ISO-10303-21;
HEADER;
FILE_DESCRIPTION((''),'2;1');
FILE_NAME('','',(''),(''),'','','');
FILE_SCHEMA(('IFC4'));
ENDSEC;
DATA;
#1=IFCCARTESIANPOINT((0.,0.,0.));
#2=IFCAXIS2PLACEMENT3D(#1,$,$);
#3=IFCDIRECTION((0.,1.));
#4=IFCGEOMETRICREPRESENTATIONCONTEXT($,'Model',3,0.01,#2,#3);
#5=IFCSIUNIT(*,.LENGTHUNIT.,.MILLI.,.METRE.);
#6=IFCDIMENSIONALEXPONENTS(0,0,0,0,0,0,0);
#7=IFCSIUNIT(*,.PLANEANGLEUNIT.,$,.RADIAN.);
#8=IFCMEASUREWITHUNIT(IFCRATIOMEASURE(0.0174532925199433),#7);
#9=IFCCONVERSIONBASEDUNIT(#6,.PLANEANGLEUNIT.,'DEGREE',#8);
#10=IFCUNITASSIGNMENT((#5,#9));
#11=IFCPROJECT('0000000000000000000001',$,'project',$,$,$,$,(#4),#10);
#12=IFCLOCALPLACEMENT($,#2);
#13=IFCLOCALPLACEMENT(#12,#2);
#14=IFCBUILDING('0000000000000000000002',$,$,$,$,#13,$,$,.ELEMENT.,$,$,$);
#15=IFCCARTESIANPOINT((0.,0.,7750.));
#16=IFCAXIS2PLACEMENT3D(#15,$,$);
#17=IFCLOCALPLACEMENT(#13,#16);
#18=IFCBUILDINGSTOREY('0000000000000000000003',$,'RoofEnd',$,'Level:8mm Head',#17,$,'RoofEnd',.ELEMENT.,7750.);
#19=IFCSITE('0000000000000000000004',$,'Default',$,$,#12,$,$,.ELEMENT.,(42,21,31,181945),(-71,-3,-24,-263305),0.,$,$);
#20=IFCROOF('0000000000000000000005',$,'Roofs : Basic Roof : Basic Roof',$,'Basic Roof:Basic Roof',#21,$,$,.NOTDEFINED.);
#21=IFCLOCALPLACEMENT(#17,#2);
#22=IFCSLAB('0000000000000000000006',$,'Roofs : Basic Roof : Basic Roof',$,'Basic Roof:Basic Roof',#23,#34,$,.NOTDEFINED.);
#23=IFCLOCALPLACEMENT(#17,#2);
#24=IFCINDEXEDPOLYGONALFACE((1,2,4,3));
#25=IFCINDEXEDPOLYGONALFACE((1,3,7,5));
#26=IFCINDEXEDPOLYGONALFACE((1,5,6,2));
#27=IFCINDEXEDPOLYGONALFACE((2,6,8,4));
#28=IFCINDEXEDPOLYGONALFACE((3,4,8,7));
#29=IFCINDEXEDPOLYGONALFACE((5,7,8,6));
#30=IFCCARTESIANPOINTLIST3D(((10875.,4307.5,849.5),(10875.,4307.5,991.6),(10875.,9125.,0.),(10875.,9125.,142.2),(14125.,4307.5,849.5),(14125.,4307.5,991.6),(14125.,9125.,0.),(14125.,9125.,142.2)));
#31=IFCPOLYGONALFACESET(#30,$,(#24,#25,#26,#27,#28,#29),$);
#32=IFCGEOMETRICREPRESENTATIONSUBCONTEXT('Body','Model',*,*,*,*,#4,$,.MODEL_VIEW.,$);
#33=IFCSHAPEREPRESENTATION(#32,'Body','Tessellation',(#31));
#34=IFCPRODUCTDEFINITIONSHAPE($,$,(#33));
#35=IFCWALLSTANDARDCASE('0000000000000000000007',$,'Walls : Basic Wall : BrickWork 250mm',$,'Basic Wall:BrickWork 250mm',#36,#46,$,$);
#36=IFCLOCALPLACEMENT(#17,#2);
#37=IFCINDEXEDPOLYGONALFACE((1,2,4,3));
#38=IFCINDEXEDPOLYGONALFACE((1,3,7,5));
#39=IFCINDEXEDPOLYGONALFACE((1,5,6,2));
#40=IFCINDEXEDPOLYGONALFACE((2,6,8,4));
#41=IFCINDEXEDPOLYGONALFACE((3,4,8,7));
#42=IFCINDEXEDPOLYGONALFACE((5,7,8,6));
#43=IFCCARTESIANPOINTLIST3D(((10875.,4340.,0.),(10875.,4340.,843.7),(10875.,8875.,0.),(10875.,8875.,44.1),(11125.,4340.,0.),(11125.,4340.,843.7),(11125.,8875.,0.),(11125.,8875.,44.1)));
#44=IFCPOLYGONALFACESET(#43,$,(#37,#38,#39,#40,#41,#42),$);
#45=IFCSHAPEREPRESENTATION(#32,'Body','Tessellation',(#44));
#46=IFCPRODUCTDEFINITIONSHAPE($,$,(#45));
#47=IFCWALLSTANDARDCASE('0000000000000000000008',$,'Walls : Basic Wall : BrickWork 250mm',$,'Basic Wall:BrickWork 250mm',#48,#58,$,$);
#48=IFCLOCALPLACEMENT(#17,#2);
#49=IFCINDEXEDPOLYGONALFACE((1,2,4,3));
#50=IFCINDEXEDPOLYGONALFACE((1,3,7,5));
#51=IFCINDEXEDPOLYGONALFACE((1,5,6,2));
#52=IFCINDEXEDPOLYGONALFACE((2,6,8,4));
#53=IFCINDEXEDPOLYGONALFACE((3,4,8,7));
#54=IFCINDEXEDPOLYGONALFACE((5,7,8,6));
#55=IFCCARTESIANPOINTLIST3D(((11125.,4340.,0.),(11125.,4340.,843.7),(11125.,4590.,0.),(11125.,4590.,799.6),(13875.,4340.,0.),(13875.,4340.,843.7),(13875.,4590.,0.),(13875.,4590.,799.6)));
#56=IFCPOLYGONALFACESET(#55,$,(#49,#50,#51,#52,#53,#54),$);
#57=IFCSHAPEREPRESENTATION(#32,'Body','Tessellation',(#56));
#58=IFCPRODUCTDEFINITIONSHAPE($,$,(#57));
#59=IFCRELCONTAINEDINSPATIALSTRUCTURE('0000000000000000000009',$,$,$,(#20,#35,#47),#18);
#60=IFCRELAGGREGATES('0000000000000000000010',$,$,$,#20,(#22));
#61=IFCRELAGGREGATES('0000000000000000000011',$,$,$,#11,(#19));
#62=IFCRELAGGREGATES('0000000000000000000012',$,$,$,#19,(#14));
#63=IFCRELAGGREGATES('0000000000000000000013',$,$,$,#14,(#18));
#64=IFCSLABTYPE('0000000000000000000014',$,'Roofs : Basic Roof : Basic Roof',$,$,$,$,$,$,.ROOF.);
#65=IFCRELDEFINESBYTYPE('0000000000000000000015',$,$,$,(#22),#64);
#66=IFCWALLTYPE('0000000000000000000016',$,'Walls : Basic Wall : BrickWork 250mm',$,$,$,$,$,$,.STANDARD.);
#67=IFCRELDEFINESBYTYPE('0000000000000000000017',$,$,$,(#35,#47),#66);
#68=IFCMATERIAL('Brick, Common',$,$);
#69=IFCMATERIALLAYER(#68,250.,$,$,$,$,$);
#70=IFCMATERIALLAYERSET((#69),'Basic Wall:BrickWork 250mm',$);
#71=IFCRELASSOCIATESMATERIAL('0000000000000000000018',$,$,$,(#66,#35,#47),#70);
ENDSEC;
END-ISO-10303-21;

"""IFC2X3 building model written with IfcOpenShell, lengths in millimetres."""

from ifc_helpers import new_model, entity, si_unit, converted_unit, direction, frame, frame_2d, origin, place, context, subcontext, project, spatial, polyline, rectangle, extrude, clip, halfspace, bounded_halfspace, material, layer, layer_set, layer_usage, type_object, element, aggregate, save


model = new_model("IFC2X3")

# Units and contexts
model_context = context("Model", 3, precision=0.01, world=origin(), true_north=direction((0.0, 1.0)))
body_context = subcontext(model_context, "Body", "Model", "MODEL_VIEW")
ifc_project = project(units=[si_unit("LENGTHUNIT", "METRE", prefix="MILLI"), converted_unit("PLANEANGLEUNIT", "DEGREE", entity("IfcRatioMeasure", 0.0174532925199433), si_unit("PLANEANGLEUNIT", "RADIAN"), dimensions=[0, 0, 0, 0, 0, 0, 0])], contexts=[model_context])

# Site, building, storey
site_placement = place(None, origin())
site = spatial("IfcSite", under=ifc_project, at=site_placement, Name="Default", CompositionType="ELEMENT", RefLatitude=(42, 21, 31, 181945), RefLongitude=(-71, -3, -24, -263305), RefElevation=0.0)
building_placement = place(site_placement, origin())
building = spatial("IfcBuilding", under=site, at=building_placement, CompositionType="ELEMENT")
storey_placement = place(building_placement, frame((0.0, 0.0, 7750.0)))
storey = spatial("IfcBuildingStorey", under=building, at=storey_placement, Name="RoofEnd", ObjectType="Level:8mm Head", LongName="RoofEnd", CompositionType="ELEMENT", Elevation=7750.0)

# Roof, slab
roof_placement = place(storey_placement, frame((10875.0, 4307.5, 0.0)))
roof = element("IfcRoof", 1, at=roof_placement, inside=storey, Name="Roofs : Basic Roof : Basic Roof", ObjectType="Basic Roof:Basic Roof", ShapeType="NOTDEFINED")
slab_type = type_object("IfcSlabType", Name="Roofs : Basic Roof : Basic Roof", PredefinedType="ROOF")
slab_placement = place(roof_placement, origin())
slab = element("IfcSlab", 2, at=slab_placement, type_object=slab_type, Name="Roofs : Basic Roof : Basic Roof", ObjectType="Basic Roof:Basic Roof", PredefinedType="NOTDEFINED", context=body_context, shape_type="SweptSolid", body=[
    extrude(rectangle(XDim=3250.0, YDim=4891.8, at=frame_2d((0.0, 0.0), x_axis=(1.0, 0.0))), frame((1625.0, 2408.7, 424.7), z_axis=(0.0, 0.173648, 0.984808), x_axis=(1.0, 0.0, 0.0)), (0.0, -0.173648, 0.984808), 142.2),
])
aggregate(roof, [slab])

# Walls
ifc_material = material(Name="Brick, Common")
ifc_layer = layer(ifc_material, 250.0)
ifc_layer_set = layer_set([ifc_layer], Name="Basic Wall:BrickWork 250mm")
wall_type = type_object("IfcWallType", Name="Walls : Basic Wall : BrickWork 250mm", PredefinedType="STANDARD", material=ifc_layer_set)
ifc_layer_usage_1 = layer_usage(ifc_layer_set, "AXIS2", "POSITIVE", -125.0)
wall_1_placement = place(storey_placement, frame((11000.0, 8875.0, 0.0), z_axis=(0.0, 0.0, 1.0), x_axis=(0.0, -1.0, 0.0)))
element("IfcWallStandardCase", 3, at=wall_1_placement, inside=storey, type_object=wall_type, material=ifc_layer_usage_1, Name="Walls : Basic Wall : BrickWork 250mm", ObjectType="Basic Wall:BrickWork 250mm", context=body_context, shape_type="Clipping", body=[
    clip(clip(extrude(rectangle(XDim=4535.0, YDim=250.0, at=frame_2d((2267.5, 0.0), x_axis=(-1.0, 0.0))), origin(), (0.0, 0.0, 1.0), 843.7), bounded_halfspace(frame((0.0, -125.0, 44.1), z_axis=(-0.173648, 0.0, 0.984808), x_axis=(0.0, -1.0, 0.0)), False, frame((0.0, -125.0, 44.1)), polyline([(0.0, 0.0), (4535.0, 0.0), (4535.0, 250.0), (4285.0, 250.0), (0.0, 250.0), (0.0, 0.0)]))), halfspace(frame((0.0, 0.0, -900.0)), True)),
])
ifc_layer_usage_2 = layer_usage(ifc_layer_set, "AXIS2", "POSITIVE", -125.0)
wall_2_placement = place(storey_placement, frame((11125.0, 4465.0, 0.0)))
element("IfcWallStandardCase", 4, at=wall_2_placement, inside=storey, type_object=wall_type, material=ifc_layer_usage_2, Name="Walls : Basic Wall : BrickWork 250mm", ObjectType="Basic Wall:BrickWork 250mm", context=body_context, shape_type="Clipping", body=[
    clip(clip(extrude(rectangle(XDim=2750.0, YDim=250.0, at=frame_2d((1375.0, 0.0), x_axis=(-1.0, 0.0))), origin(), (0.0, 0.0, 1.0), 843.7), bounded_halfspace(frame((0.0, -125.0, 843.7), z_axis=(0.0, 0.173648, 0.984808), x_axis=(-1.0, 0.0, 0.0)), False, frame((0.0, -125.0, 843.7)), polyline([(0.0, 0.0), (2750.0, 0.0), (2750.0, 250.0), (0.0, 250.0), (0.0, 0.0)]))), halfspace(frame((0.0, 0.0, -900.0)), True)),
])

save(model, "model.ifc")
